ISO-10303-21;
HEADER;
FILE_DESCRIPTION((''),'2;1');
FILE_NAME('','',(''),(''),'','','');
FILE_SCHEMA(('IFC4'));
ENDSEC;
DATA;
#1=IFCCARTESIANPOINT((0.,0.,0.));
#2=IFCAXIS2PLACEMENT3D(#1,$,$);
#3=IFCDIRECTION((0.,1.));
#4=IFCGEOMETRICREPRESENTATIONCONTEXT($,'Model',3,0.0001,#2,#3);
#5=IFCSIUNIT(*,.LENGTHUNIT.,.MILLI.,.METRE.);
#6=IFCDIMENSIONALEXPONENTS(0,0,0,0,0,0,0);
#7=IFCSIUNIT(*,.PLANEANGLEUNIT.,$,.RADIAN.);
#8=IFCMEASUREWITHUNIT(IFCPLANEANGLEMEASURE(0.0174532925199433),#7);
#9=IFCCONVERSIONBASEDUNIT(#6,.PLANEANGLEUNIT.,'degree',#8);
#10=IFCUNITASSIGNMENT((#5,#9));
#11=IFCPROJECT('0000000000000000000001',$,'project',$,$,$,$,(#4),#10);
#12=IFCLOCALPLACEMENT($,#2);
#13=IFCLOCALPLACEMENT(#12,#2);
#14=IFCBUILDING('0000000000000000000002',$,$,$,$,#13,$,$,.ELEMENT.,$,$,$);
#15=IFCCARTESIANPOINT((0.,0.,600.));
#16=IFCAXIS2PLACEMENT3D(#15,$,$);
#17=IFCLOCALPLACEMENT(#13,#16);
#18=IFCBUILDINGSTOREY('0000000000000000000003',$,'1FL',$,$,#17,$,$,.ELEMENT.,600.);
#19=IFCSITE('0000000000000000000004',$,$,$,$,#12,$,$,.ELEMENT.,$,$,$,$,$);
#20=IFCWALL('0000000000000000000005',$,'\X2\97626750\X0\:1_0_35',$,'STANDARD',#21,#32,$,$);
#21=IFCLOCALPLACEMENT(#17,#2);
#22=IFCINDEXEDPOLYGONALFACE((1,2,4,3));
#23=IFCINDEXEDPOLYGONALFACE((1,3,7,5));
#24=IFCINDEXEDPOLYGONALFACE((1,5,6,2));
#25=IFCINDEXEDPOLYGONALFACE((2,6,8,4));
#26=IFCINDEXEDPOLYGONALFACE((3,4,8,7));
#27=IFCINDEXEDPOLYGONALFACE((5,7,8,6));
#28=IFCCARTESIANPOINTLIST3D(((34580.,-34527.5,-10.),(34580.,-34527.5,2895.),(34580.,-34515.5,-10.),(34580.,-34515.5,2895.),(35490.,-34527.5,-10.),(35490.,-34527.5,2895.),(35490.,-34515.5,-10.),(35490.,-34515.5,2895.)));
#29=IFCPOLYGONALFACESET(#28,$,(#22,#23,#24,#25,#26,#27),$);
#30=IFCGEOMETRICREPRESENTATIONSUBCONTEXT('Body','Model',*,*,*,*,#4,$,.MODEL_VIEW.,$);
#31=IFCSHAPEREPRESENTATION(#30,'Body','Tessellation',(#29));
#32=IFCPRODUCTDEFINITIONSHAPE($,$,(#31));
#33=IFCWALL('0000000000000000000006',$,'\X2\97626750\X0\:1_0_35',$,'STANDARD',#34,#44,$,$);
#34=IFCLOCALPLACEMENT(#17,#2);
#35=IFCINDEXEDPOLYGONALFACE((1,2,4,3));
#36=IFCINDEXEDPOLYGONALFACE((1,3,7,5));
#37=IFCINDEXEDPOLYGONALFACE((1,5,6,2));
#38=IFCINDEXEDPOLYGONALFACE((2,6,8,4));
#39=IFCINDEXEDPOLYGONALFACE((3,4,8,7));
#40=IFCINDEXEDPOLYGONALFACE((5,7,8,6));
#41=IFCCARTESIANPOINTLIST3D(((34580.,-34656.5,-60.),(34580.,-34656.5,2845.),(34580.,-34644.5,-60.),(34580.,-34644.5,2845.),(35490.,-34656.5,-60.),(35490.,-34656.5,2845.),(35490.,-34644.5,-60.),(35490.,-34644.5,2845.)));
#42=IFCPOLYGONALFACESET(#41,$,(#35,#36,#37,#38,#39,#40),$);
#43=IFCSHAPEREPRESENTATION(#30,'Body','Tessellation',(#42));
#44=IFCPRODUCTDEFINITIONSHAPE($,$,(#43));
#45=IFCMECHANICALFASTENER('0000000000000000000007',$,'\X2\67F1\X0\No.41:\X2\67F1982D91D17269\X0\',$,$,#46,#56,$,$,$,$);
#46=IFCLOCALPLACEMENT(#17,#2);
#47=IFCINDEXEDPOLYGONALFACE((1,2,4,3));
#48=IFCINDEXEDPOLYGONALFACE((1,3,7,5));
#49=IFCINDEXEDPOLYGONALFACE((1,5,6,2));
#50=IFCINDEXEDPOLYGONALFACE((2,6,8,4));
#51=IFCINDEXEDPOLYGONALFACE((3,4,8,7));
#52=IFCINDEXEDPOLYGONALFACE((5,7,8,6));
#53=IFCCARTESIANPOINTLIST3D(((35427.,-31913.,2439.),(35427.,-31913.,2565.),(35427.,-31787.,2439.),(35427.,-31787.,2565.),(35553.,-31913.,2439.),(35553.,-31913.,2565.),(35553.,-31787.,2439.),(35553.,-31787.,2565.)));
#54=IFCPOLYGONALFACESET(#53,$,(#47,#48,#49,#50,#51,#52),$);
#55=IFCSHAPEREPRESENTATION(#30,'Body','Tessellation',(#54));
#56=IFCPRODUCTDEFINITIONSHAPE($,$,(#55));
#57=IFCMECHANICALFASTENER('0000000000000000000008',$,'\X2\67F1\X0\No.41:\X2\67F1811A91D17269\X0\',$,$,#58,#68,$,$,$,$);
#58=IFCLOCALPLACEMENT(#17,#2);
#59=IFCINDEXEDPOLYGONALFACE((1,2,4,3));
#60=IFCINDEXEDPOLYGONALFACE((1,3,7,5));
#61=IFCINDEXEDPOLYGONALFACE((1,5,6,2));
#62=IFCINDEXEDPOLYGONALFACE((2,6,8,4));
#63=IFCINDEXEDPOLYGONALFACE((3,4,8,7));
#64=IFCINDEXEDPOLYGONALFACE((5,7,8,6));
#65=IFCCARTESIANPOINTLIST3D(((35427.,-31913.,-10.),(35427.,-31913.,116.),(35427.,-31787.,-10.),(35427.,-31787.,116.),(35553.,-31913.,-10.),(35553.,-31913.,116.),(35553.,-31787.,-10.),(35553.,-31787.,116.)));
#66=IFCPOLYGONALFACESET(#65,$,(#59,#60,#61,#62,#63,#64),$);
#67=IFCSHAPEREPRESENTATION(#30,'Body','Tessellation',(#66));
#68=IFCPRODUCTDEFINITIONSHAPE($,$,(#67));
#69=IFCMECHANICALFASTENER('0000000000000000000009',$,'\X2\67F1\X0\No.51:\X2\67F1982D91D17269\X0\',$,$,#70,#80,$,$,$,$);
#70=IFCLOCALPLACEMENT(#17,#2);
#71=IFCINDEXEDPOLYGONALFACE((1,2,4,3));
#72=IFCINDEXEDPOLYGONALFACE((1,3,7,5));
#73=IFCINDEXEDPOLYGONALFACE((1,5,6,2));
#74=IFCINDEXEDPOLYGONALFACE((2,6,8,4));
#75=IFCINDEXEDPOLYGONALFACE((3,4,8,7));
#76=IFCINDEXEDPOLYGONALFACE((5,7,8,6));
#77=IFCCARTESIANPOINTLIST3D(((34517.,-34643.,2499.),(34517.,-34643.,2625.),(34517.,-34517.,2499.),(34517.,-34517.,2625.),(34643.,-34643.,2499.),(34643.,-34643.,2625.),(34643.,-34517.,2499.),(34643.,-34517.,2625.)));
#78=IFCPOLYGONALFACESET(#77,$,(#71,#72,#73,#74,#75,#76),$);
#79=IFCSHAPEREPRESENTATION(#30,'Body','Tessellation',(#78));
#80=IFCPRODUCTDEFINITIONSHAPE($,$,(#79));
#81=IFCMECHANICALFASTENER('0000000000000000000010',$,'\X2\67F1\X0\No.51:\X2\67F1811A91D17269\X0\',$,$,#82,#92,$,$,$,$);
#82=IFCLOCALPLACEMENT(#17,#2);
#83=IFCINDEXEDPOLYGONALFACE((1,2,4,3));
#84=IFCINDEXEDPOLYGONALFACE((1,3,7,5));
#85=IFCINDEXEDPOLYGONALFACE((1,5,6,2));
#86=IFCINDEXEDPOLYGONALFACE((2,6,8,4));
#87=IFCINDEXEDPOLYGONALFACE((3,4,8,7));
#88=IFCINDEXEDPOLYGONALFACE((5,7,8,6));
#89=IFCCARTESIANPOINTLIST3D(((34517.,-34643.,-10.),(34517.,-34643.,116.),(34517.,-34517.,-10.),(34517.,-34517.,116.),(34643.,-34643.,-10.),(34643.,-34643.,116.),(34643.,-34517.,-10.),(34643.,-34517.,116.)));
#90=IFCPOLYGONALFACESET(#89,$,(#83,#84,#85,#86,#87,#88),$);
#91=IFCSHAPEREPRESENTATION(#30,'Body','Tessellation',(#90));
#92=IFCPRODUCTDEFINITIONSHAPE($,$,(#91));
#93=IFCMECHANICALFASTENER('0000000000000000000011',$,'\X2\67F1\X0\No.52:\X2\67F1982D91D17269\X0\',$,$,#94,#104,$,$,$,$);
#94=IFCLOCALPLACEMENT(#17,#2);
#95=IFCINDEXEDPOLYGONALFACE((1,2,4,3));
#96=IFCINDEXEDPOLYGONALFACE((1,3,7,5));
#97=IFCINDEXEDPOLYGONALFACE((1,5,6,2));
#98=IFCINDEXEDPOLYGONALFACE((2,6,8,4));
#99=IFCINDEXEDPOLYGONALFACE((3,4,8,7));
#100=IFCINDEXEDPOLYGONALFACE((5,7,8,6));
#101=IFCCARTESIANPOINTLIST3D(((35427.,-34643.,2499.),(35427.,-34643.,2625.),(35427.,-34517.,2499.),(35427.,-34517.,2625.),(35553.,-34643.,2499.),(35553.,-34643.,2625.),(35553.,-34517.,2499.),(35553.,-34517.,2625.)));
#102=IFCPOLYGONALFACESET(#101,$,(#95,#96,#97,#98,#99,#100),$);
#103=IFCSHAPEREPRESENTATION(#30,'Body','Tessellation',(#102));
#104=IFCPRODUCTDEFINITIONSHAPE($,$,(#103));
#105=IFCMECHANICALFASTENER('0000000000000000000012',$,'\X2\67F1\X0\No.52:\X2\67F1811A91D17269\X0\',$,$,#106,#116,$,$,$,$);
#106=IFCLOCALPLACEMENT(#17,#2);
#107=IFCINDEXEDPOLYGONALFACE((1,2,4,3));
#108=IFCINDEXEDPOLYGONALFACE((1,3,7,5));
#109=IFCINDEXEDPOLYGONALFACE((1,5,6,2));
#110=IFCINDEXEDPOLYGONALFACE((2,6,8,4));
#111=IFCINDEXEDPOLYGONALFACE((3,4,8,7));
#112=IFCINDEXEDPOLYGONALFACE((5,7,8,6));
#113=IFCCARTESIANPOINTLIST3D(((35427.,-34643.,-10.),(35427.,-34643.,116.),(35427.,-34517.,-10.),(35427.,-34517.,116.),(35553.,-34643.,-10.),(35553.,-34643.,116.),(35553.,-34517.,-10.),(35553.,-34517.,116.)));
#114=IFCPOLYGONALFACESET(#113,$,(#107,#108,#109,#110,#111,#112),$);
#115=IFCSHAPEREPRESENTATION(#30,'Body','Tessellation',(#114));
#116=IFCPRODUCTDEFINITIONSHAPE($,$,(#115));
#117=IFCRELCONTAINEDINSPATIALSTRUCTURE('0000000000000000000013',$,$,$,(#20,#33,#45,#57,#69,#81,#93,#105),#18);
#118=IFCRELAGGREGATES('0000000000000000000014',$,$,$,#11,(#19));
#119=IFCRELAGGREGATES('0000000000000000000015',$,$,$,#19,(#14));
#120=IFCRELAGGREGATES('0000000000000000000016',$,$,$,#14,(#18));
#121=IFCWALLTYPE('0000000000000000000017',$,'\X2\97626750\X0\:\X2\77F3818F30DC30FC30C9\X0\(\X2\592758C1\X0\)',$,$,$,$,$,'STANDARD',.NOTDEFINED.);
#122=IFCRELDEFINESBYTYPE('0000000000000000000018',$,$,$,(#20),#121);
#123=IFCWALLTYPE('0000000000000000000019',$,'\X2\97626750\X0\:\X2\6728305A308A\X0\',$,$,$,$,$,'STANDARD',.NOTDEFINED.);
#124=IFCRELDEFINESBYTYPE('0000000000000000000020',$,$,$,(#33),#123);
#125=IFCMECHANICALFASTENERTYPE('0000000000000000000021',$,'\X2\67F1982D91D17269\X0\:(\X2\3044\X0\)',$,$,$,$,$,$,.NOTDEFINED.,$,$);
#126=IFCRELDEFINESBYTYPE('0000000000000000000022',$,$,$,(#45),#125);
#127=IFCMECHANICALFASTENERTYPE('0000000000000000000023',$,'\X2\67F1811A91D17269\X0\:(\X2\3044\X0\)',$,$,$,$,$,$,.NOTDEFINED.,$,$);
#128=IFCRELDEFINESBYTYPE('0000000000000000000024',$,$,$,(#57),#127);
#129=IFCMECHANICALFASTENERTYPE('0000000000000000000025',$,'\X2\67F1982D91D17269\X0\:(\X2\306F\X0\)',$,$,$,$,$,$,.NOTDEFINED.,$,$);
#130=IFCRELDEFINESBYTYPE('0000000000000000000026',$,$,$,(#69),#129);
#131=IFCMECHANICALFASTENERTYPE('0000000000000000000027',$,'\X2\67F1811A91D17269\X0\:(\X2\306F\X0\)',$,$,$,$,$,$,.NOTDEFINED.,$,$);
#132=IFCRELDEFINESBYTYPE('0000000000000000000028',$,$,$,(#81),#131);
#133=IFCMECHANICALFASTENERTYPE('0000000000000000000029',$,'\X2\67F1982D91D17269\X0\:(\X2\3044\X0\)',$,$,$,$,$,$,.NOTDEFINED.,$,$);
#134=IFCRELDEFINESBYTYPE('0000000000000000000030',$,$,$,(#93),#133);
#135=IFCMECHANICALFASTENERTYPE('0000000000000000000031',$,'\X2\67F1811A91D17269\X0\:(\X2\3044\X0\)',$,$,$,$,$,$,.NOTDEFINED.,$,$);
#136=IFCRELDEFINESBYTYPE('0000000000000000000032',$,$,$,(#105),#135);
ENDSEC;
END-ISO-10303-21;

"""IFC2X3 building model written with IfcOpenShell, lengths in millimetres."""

from ifc_helpers import new_model, entity, si_unit, converted_unit, direction, frame, origin, origin_with_axes, origin_2d, place, context, subcontext, project, spatial, polyline, rectangle, outline, extrude, type_object, element, save


model = new_model("IFC2X3")

# Units and contexts
model_context = context("Model", 3, precision=0.0001, world=origin(), true_north=direction((0.0, 1.0)))
body_context = subcontext(model_context, "Body", "Model", "MODEL_VIEW")
ifc_project = project(units=[si_unit("LENGTHUNIT", "METRE", prefix="MILLI"), converted_unit("PLANEANGLEUNIT", "degree", entity("IfcPlaneAngleMeasure", 0.0174532925199433), si_unit("PLANEANGLEUNIT", "RADIAN"), dimensions=[0, 0, 0, 0, 0, 0, 0])], contexts=[model_context])

# Site, building, storey
site_placement = place(None, origin())
site = spatial("IfcSite", under=ifc_project, at=site_placement, CompositionType="ELEMENT")
building_placement = place(site_placement, origin())
building = spatial("IfcBuilding", under=site, at=building_placement, CompositionType="ELEMENT")
storey_placement = place(building_placement, frame((0.0, 0.0, 600.0)))
storey = spatial("IfcBuildingStorey", under=building, at=storey_placement, Name="1FL", CompositionType="ELEMENT", Elevation=600.0)

# Walls
wall_type_1 = type_object("IfcWallType", Name="面材:石膏ボード(大壁)", ElementType="STANDARD", PredefinedType="NOTDEFINED")
wall_1_placement = place(storey_placement, frame((35035.0, -34515.5, -10.0), z_axis=(0.0, -1.0, 0.0), x_axis=(1.0, 0.0, 0.0)))
element("IfcWall", 1, at=wall_1_placement, inside=storey, type_object=wall_type_1, Name="面材:1_0_35", ObjectType="STANDARD", context=body_context, shape_type="SweptSolid", body=[
    extrude(outline(polyline([(455.0, 0.0, 0.0), (-455.0, 0.0, 0.0), (-455.0, 2905.0, 0.0), (455.0, 2905.0, 0.0), (455.0, 0.0, 0.0)])), origin_with_axes(), (0.0, 0.0, 1.0), 12.0),
])
wall_type_2 = type_object("IfcWallType", Name="面材:木ずり", ElementType="STANDARD", PredefinedType="NOTDEFINED")
wall_2_placement = place(storey_placement, frame((35035.0, -34644.5, -60.0), z_axis=(0.0, -1.0, 0.0), x_axis=(1.0, 0.0, 0.0)))
element("IfcWall", 2, at=wall_2_placement, inside=storey, type_object=wall_type_2, Name="面材:1_0_35", ObjectType="STANDARD", context=body_context, shape_type="SweptSolid", body=[
    extrude(outline(polyline([(455.0, 0.0, 0.0), (-455.0, 0.0, 0.0), (-455.0, 2905.0, 0.0), (455.0, 2905.0, 0.0), (455.0, 0.0, 0.0)])), origin_with_axes(), (0.0, 0.0, 1.0), 12.0),
])

# Mechanical fasteners
mechanical_fastener_type_1 = type_object("IfcMechanicalFastenerType", Name="柱頭金物:(い)")
mechanical_fastener_1_placement = place(storey_placement, frame((35490.0, -31850.0, 2439.0)))
element("IfcMechanicalFastener", 3, at=mechanical_fastener_1_placement, inside=storey, type_object=mechanical_fastener_type_1, Name="柱No.41:柱頭金物", context=body_context, shape_type="SweptSolid", body=[
    extrude(rectangle(XDim=126.0, YDim=126.0, at=origin_2d()), origin_with_axes(), (0.0, 0.0, 1.0), 126.0),
])
mechanical_fastener_type_2 = type_object("IfcMechanicalFastenerType", Name="柱脚金物:(い)")
mechanical_fastener_2_placement = place(storey_placement, frame((35490.0, -31850.0, -10.0)))
element("IfcMechanicalFastener", 4, at=mechanical_fastener_2_placement, inside=storey, type_object=mechanical_fastener_type_2, Name="柱No.41:柱脚金物", context=body_context, shape_type="SweptSolid", body=[
    extrude(rectangle(XDim=126.0, YDim=126.0, at=origin_2d()), origin_with_axes(), (0.0, 0.0, 1.0), 126.0),
])
mechanical_fastener_type_3 = type_object("IfcMechanicalFastenerType", Name="柱頭金物:(は)")
mechanical_fastener_3_placement = place(storey_placement, frame((34580.0, -34580.0, 2499.0)))
element("IfcMechanicalFastener", 5, at=mechanical_fastener_3_placement, inside=storey, type_object=mechanical_fastener_type_3, Name="柱No.51:柱頭金物", context=body_context, shape_type="SweptSolid", body=[
    extrude(rectangle(XDim=126.0, YDim=126.0, at=origin_2d()), origin_with_axes(), (0.0, 0.0, 1.0), 126.0),
])
mechanical_fastener_type_4 = type_object("IfcMechanicalFastenerType", Name="柱脚金物:(は)")
mechanical_fastener_4_placement = place(storey_placement, frame((34580.0, -34580.0, -10.0)))
element("IfcMechanicalFastener", 6, at=mechanical_fastener_4_placement, inside=storey, type_object=mechanical_fastener_type_4, Name="柱No.51:柱脚金物", context=body_context, shape_type="SweptSolid", body=[
    extrude(rectangle(XDim=126.0, YDim=126.0, at=origin_2d()), origin_with_axes(), (0.0, 0.0, 1.0), 126.0),
])
mechanical_fastener_type_5 = type_object("IfcMechanicalFastenerType", Name="柱頭金物:(い)")
mechanical_fastener_5_placement = place(storey_placement, frame((35490.0, -34580.0, 2499.0)))
element("IfcMechanicalFastener", 7, at=mechanical_fastener_5_placement, inside=storey, type_object=mechanical_fastener_type_5, Name="柱No.52:柱頭金物", context=body_context, shape_type="SweptSolid", body=[
    extrude(rectangle(XDim=126.0, YDim=126.0, at=origin_2d()), origin_with_axes(), (0.0, 0.0, 1.0), 126.0),
])
mechanical_fastener_type_6 = type_object("IfcMechanicalFastenerType", Name="柱脚金物:(い)")
mechanical_fastener_6_placement = place(storey_placement, frame((35490.0, -34580.0, -10.0)))
element("IfcMechanicalFastener", 8, at=mechanical_fastener_6_placement, inside=storey, type_object=mechanical_fastener_type_6, Name="柱No.52:柱脚金物", context=body_context, shape_type="SweptSolid", body=[
    extrude(rectangle(XDim=126.0, YDim=126.0, at=origin_2d()), origin_with_axes(), (0.0, 0.0, 1.0), 126.0),
])

save(model, "model.ifc")
